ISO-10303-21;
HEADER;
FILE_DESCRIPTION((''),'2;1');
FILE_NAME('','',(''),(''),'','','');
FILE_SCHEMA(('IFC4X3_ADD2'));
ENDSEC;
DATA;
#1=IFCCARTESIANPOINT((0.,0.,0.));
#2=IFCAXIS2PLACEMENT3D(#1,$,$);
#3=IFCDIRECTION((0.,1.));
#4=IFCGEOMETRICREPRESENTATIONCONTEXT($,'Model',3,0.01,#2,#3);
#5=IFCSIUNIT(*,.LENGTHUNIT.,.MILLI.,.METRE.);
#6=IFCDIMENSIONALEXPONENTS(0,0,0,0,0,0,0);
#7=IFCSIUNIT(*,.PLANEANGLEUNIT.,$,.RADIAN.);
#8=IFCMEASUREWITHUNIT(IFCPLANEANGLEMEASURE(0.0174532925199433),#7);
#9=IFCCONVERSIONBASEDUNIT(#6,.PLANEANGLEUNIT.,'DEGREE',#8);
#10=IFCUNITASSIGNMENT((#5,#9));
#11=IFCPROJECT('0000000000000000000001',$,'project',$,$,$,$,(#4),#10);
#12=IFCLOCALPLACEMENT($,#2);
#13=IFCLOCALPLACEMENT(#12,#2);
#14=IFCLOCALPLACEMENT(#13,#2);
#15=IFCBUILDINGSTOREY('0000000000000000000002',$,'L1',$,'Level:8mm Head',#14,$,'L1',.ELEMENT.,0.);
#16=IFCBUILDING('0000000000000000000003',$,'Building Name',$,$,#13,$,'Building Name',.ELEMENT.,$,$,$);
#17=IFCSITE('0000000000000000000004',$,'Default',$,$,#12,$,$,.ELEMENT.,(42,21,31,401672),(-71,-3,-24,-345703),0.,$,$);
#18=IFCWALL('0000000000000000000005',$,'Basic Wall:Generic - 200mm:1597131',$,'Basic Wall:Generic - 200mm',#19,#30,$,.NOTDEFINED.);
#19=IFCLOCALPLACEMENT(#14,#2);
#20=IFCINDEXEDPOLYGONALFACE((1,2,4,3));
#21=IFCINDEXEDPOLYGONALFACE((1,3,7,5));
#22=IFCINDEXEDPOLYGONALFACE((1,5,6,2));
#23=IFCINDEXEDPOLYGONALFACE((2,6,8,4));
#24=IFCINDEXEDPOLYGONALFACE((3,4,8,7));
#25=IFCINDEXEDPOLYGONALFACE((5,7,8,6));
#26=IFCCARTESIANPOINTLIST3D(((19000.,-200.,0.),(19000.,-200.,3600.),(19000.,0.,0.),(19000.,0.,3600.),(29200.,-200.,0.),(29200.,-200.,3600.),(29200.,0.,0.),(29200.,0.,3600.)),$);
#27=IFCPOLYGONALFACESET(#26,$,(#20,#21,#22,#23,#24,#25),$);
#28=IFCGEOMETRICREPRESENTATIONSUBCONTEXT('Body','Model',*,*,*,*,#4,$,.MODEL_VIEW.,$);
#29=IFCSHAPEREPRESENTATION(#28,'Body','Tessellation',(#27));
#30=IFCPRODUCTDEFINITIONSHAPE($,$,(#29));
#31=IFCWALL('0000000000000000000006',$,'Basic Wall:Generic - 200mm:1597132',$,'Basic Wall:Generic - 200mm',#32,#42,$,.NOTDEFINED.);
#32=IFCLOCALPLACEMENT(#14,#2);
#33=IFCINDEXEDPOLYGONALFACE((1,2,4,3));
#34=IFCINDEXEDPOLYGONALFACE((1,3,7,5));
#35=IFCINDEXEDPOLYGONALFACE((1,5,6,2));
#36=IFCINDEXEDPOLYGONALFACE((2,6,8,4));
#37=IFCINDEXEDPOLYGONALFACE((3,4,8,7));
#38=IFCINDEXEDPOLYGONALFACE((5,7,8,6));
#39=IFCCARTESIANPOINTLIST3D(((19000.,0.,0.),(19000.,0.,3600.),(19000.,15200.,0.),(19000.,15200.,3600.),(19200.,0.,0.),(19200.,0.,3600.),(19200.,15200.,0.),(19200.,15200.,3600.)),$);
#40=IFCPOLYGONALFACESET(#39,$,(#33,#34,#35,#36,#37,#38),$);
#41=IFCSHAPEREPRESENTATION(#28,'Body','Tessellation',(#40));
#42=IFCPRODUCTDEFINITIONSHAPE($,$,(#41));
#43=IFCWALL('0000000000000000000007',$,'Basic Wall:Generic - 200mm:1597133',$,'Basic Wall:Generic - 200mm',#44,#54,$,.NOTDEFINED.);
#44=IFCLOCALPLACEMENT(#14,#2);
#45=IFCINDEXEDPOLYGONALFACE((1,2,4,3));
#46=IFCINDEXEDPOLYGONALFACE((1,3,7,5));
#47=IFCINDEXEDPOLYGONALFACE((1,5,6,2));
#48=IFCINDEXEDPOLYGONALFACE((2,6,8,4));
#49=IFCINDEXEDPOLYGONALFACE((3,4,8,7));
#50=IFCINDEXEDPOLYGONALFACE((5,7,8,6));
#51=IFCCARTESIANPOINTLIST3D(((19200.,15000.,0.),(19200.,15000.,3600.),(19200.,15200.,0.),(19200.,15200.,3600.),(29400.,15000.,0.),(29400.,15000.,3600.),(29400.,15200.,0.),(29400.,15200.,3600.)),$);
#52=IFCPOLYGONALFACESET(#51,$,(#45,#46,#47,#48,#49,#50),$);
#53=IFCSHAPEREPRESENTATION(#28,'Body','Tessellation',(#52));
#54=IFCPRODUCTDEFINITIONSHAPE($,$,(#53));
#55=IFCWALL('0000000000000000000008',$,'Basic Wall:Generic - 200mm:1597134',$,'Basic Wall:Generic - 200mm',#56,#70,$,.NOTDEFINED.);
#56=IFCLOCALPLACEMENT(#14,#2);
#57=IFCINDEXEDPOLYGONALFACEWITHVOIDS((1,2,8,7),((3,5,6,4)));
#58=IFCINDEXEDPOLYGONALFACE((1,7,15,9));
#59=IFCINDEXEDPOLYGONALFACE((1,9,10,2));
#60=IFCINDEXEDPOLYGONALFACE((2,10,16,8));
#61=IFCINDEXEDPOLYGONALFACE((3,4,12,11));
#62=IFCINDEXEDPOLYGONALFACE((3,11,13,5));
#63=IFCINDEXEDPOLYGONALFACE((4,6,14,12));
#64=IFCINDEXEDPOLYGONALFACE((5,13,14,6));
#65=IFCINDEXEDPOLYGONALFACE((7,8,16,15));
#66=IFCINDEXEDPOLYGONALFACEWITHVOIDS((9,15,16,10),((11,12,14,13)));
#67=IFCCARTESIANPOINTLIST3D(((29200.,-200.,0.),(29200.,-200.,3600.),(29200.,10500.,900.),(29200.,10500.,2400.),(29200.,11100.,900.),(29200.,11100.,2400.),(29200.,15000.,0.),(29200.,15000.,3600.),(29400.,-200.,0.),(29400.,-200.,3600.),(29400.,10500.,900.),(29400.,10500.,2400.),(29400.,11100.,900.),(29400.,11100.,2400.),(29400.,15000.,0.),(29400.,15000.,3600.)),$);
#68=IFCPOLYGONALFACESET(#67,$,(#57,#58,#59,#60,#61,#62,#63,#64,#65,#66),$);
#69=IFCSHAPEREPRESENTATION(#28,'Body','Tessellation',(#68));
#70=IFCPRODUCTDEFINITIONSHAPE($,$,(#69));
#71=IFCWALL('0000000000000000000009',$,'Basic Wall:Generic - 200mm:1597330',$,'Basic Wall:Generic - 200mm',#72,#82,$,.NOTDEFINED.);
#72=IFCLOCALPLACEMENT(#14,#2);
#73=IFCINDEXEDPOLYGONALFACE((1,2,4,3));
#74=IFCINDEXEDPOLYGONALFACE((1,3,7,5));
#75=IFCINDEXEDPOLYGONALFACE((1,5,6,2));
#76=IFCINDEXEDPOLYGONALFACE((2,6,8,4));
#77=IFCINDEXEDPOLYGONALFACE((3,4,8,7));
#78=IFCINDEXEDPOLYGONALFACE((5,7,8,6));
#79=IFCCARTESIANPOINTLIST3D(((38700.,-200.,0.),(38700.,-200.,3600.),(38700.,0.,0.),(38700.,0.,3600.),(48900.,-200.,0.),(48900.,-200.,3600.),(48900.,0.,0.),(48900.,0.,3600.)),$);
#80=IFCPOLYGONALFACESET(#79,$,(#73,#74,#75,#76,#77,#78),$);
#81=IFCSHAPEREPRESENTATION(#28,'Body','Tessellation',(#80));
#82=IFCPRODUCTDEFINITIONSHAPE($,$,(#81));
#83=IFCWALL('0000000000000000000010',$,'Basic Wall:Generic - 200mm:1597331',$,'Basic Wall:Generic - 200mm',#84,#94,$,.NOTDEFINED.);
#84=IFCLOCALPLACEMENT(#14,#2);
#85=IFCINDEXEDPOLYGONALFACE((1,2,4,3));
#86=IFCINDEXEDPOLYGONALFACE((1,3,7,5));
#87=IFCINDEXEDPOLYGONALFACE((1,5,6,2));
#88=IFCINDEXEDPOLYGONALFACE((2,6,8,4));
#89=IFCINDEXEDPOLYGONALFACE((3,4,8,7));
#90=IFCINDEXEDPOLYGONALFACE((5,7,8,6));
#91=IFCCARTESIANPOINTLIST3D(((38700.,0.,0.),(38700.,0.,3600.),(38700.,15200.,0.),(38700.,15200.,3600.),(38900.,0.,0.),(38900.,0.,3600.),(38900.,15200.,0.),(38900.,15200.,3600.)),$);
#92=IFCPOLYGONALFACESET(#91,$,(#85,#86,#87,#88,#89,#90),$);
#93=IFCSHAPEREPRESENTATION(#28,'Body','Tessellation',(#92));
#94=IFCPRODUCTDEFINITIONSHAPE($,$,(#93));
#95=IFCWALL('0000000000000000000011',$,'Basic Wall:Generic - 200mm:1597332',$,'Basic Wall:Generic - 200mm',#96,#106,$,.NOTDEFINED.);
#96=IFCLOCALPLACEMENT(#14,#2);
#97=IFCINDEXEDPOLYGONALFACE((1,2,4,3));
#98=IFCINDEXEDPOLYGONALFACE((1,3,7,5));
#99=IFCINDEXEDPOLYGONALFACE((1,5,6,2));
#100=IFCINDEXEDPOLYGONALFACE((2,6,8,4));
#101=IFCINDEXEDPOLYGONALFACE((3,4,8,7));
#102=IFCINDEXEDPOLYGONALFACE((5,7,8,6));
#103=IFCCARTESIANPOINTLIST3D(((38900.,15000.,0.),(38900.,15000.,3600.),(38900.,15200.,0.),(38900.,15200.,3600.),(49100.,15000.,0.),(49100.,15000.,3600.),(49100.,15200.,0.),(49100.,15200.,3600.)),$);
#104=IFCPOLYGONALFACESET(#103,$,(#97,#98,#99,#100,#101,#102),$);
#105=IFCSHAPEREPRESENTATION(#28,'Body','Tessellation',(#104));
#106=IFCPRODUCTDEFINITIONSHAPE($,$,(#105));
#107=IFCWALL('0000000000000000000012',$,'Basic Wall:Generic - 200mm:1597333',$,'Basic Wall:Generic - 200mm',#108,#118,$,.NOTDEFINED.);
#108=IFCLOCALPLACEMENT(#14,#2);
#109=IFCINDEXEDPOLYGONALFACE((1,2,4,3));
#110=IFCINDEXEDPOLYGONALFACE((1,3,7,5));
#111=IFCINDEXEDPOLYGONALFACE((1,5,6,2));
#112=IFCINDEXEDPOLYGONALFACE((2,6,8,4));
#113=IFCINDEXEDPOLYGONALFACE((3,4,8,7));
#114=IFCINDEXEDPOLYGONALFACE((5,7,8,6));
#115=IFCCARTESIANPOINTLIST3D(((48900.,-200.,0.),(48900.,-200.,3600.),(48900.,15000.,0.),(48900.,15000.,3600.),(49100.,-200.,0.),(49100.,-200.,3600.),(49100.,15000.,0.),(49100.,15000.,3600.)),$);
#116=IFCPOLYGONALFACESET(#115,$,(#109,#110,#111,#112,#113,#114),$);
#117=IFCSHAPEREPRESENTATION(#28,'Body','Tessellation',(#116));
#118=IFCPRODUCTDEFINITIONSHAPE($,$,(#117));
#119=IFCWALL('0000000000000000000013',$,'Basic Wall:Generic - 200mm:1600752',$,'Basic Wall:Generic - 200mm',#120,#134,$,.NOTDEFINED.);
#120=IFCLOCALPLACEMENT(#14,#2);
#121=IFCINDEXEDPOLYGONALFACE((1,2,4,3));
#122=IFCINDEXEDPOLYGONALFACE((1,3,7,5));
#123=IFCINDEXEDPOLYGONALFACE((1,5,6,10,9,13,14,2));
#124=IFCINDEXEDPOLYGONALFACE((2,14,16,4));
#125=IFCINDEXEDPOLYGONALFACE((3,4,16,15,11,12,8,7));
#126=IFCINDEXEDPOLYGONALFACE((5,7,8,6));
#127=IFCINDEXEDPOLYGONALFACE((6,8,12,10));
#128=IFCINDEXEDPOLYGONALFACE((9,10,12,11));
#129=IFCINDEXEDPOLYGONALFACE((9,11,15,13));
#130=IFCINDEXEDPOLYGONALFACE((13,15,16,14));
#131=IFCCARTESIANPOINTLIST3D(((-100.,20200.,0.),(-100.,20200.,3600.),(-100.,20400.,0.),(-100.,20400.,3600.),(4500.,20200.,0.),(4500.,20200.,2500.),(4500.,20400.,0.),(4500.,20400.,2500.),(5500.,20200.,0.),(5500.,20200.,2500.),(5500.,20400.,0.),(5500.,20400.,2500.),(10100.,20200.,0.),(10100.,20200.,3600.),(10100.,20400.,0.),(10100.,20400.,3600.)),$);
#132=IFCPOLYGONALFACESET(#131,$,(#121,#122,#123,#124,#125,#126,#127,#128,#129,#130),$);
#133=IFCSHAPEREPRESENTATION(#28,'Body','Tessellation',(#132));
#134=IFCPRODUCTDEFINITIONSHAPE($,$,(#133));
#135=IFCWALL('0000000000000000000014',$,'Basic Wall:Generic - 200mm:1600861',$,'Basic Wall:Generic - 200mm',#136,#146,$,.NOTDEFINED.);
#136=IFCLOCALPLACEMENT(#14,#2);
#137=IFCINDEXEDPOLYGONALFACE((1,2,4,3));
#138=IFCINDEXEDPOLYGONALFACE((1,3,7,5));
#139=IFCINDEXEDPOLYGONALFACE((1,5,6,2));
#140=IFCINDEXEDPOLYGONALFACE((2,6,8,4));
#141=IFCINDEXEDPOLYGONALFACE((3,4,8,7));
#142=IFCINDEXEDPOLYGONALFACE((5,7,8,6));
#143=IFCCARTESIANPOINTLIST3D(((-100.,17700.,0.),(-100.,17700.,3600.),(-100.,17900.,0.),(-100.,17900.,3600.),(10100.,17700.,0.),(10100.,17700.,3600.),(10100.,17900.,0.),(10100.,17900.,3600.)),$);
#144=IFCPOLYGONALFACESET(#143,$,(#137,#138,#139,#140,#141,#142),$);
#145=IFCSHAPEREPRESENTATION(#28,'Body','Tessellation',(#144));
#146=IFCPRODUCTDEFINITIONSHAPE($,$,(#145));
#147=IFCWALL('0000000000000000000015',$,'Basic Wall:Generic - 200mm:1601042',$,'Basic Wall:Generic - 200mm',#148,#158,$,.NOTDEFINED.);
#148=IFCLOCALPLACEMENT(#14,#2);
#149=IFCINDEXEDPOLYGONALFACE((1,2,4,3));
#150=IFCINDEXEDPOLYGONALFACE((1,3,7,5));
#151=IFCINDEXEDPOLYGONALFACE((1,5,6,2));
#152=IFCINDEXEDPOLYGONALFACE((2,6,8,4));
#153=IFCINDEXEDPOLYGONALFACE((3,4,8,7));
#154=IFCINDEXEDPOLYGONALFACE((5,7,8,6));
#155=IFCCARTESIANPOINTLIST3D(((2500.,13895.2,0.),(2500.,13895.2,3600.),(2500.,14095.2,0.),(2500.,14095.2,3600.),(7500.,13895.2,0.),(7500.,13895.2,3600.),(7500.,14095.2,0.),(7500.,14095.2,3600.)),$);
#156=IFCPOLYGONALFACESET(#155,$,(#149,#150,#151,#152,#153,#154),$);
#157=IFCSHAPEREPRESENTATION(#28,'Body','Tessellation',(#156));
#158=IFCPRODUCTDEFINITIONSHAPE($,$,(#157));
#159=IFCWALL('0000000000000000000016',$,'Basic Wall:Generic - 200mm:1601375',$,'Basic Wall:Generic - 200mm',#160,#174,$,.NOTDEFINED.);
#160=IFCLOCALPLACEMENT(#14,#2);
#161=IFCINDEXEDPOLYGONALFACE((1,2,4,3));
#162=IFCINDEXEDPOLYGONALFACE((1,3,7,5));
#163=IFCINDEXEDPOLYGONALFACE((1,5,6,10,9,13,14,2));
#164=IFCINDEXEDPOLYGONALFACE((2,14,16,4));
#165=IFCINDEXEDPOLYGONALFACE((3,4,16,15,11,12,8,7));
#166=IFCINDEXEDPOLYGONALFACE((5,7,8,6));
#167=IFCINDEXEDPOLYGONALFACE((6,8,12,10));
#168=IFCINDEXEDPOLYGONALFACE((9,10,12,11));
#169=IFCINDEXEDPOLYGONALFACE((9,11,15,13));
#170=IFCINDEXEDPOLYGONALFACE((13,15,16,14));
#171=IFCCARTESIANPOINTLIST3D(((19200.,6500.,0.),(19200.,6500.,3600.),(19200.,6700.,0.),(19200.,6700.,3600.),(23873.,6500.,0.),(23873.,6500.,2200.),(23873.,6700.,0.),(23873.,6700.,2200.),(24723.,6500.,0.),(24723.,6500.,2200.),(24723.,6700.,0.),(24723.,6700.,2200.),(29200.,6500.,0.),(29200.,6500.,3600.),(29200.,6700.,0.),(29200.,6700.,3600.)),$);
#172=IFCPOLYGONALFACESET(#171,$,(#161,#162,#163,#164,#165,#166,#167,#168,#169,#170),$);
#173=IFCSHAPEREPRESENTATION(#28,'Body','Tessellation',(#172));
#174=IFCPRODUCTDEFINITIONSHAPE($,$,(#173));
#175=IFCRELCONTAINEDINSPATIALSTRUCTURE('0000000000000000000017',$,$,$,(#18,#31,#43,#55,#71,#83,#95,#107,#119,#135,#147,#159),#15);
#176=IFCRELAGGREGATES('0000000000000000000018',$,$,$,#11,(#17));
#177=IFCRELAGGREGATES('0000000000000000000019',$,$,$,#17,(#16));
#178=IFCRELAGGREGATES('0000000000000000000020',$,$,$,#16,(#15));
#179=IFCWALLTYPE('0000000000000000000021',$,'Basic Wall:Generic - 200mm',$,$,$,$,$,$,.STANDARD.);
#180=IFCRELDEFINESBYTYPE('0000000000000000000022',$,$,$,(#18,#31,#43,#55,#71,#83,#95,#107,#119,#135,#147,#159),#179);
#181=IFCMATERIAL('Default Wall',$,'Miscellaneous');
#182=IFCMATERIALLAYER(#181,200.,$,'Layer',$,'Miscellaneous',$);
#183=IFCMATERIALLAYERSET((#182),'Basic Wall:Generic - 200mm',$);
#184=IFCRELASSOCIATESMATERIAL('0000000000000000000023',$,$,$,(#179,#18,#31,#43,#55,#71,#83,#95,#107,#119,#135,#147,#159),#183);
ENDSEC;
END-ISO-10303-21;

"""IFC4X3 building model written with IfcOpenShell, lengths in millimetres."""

from ifc_helpers import new_model, entity, si_unit, converted_unit, direction, frame, frame_2d, origin, origin_2d_with_axis, place, context, subcontext, project, spatial, rectangle, extrude, material, layer, layer_set, type_object, element, save


model = new_model("IFC4X3")

# Units and contexts
model_context = context("Model", 3, precision=0.01, world=origin(), true_north=direction((0.0, 1.0)))
body_context = subcontext(model_context, "Body", "Model", "MODEL_VIEW")
ifc_project = project(units=[si_unit("LENGTHUNIT", "METRE", prefix="MILLI"), converted_unit("PLANEANGLEUNIT", "DEGREE", entity("IfcPlaneAngleMeasure", 0.0174532925199433), si_unit("PLANEANGLEUNIT", "RADIAN"), dimensions=[0, 0, 0, 0, 0, 0, 0])], contexts=[model_context])

# Site, building, storey
site_placement = place(None, origin())
site = spatial("IfcSite", under=ifc_project, at=site_placement, Name="Default", CompositionType="ELEMENT", RefLatitude=(42, 21, 31, 401672), RefLongitude=(-71, -3, -24, -345703), RefElevation=0.0)
building_placement = place(site_placement, origin())
building = spatial("IfcBuilding", under=site, at=building_placement, Name="Building Name", LongName="Building Name", CompositionType="ELEMENT")
storey_placement = place(building_placement, origin())
storey = spatial("IfcBuildingStorey", under=building, at=storey_placement, Name="L1", ObjectType="Level:8mm Head", LongName="L1", CompositionType="ELEMENT", Elevation=0.0)

# Walls
ifc_material_1 = material(Name="Default Wall", Category="Miscellaneous")
ifc_layer_1 = layer(ifc_material_1, 200.0, Name="Layer", Category="Miscellaneous")
ifc_layer_set_1 = layer_set([ifc_layer_1], Name="Basic Wall:Generic - 200mm")
wall_type_1 = type_object("IfcWallType", Name="Basic Wall:Generic - 200mm", PredefinedType="STANDARD", material=ifc_layer_set_1)
wall_1_placement = place(storey_placement, frame((19000.0, -100.0, 0.0)))
element("IfcWall", 1, at=wall_1_placement, inside=storey, type_object=wall_type_1, material=ifc_layer_set_1, Name="Basic Wall:Generic - 200mm:1597131", ObjectType="Basic Wall:Generic - 200mm", PredefinedType="NOTDEFINED", context=body_context, shape_type="SweptSolid", body=[
    extrude(rectangle(XDim=10200.0, YDim=200.0, at=frame_2d((5100.0, 0.0), x_axis=(-1.0, 0.0))), origin(), (0.0, 0.0, 1.0), 3600.0),
])
wall_2_placement = place(storey_placement, frame((19100.0, 15200.0, 0.0), z_axis=(0.0, 0.0, 1.0), x_axis=(0.0, -1.0, 0.0)))
element("IfcWall", 2, at=wall_2_placement, inside=storey, type_object=wall_type_1, material=ifc_layer_set_1, Name="Basic Wall:Generic - 200mm:1597132", ObjectType="Basic Wall:Generic - 200mm", PredefinedType="NOTDEFINED", context=body_context, shape_type="SweptSolid", body=[
    extrude(rectangle(XDim=15200.0, YDim=200.0, at=frame_2d((7600.0, 0.0), x_axis=(-1.0, 0.0))), origin(), (0.0, 0.0, 1.0), 3600.0),
])
wall_3_placement = place(storey_placement, frame((29400.0, 15100.0, 0.0), z_axis=(0.0, 0.0, 1.0), x_axis=(-1.0, 0.0, 0.0)))
element("IfcWall", 3, at=wall_3_placement, inside=storey, type_object=wall_type_1, material=ifc_layer_set_1, Name="Basic Wall:Generic - 200mm:1597133", ObjectType="Basic Wall:Generic - 200mm", PredefinedType="NOTDEFINED", context=body_context, shape_type="SweptSolid", body=[
    extrude(rectangle(XDim=10200.0, YDim=200.0, at=frame_2d((5100.0, 0.0), x_axis=(-1.0, 0.0))), origin(), (0.0, 0.0, 1.0), 3600.0),
])

# Wall, opening
wall_4_placement = place(storey_placement, frame((29300.0, -200.0, 0.0), z_axis=(0.0, 0.0, 1.0), x_axis=(0.0, 1.0, 0.0)))
wall_4 = element("IfcWall", 4, at=wall_4_placement, inside=storey, type_object=wall_type_1, material=ifc_layer_set_1, Name="Basic Wall:Generic - 200mm:1597134", ObjectType="Basic Wall:Generic - 200mm", PredefinedType="NOTDEFINED", context=body_context, shape_type="SweptSolid", body=[
    extrude(rectangle(XDim=15200.0, YDim=200.0, at=frame_2d((7600.0, 0.0), x_axis=(-1.0, 0.0))), origin(), (0.0, 0.0, 1.0), 3600.0),
])
opening_1_placement = place(wall_4_placement, frame((11300.0, 100.0, 900.0)))
element("IfcOpeningElement", 5, at=opening_1_placement, cuts=wall_4, PredefinedType="OPENING", context=body_context, shape_type="SweptSolid", body=[
    extrude(rectangle(XDim=1500.0, YDim=600.0, at=frame_2d((750.0, 300.0), x_axis=(-1.0, 0.0))), frame((0.0, 0.0, 0.0), z_axis=(0.0, -1.0, 0.0), x_axis=(0.0, 0.0, 1.0)), (0.0, 0.0, 1.0), 200.0),
])

# Walls
wall_5_placement = place(storey_placement, frame((38700.0, -100.0, 0.0)))
element("IfcWall", 6, at=wall_5_placement, inside=storey, type_object=wall_type_1, material=ifc_layer_set_1, Name="Basic Wall:Generic - 200mm:1597330", ObjectType="Basic Wall:Generic - 200mm", PredefinedType="NOTDEFINED", context=body_context, shape_type="SweptSolid", body=[
    extrude(rectangle(XDim=10200.0, YDim=200.0, at=frame_2d((5100.0, 0.0), x_axis=(-1.0, 0.0))), origin(), (0.0, 0.0, 1.0), 3600.0),
])
wall_6_placement = place(storey_placement, frame((38800.0, 15200.0, 0.0), z_axis=(0.0, 0.0, 1.0), x_axis=(0.0, -1.0, 0.0)))
element("IfcWall", 7, at=wall_6_placement, inside=storey, type_object=wall_type_1, material=ifc_layer_set_1, Name="Basic Wall:Generic - 200mm:1597331", ObjectType="Basic Wall:Generic - 200mm", PredefinedType="NOTDEFINED", context=body_context, shape_type="SweptSolid", body=[
    extrude(rectangle(XDim=15200.0, YDim=200.0, at=frame_2d((7600.0, 0.0), x_axis=(-1.0, 0.0))), origin(), (0.0, 0.0, 1.0), 3600.0),
])
wall_7_placement = place(storey_placement, frame((49100.0, 15100.0, 0.0), z_axis=(0.0, 0.0, 1.0), x_axis=(-1.0, 0.0, 0.0)))
element("IfcWall", 8, at=wall_7_placement, inside=storey, type_object=wall_type_1, material=ifc_layer_set_1, Name="Basic Wall:Generic - 200mm:1597332", ObjectType="Basic Wall:Generic - 200mm", PredefinedType="NOTDEFINED", context=body_context, shape_type="SweptSolid", body=[
    extrude(rectangle(XDim=10200.0, YDim=200.0, at=frame_2d((5100.0, 0.0), x_axis=(-1.0, 0.0))), origin(), (0.0, 0.0, 1.0), 3600.0),
])
wall_8_placement = place(storey_placement, frame((49000.0, -200.0, 0.0), z_axis=(0.0, 0.0, 1.0), x_axis=(0.0, 1.0, 0.0)))
element("IfcWall", 9, at=wall_8_placement, inside=storey, type_object=wall_type_1, material=ifc_layer_set_1, Name="Basic Wall:Generic - 200mm:1597333", ObjectType="Basic Wall:Generic - 200mm", PredefinedType="NOTDEFINED", context=body_context, shape_type="SweptSolid", body=[
    extrude(rectangle(XDim=15200.0, YDim=200.0, at=frame_2d((7600.0, 0.0), x_axis=(-1.0, 0.0))), origin(), (0.0, 0.0, 1.0), 3600.0),
])

# Wall, opening
wall_9_placement = place(storey_placement, frame((10100.0, 20300.0, 0.0), z_axis=(0.0, 0.0, 1.0), x_axis=(-1.0, 0.0, 0.0)))
wall_9 = element("IfcWall", 10, at=wall_9_placement, inside=storey, type_object=wall_type_1, material=ifc_layer_set_1, Name="Basic Wall:Generic - 200mm:1600752", ObjectType="Basic Wall:Generic - 200mm", PredefinedType="NOTDEFINED", context=body_context, shape_type="SweptSolid", body=[
    extrude(rectangle(XDim=10200.0, YDim=200.0, at=frame_2d((5100.0, 0.0), x_axis=(1.0, 0.0))), origin(), (0.0, 0.0, 1.0), 3600.0),
])
opening_2_placement = place(wall_9_placement, frame((5600.0, 100.0, 0.0)))
element("IfcOpeningElement", 11, at=opening_2_placement, cuts=wall_9, PredefinedType="OPENING", context=body_context, shape_type="SweptSolid", body=[
    extrude(rectangle(XDim=2500.0, YDim=1000.0, at=origin_2d_with_axis()), frame((-500.0, -200.0, 1250.0), z_axis=(0.0, 1.0, 0.0), x_axis=(0.0, 0.0, -1.0)), (0.0, 0.0, 1.0), 200.0),
])

# Walls
wall_10_placement = place(storey_placement, frame((10100.0, 17800.0, 0.0), z_axis=(0.0, 0.0, 1.0), x_axis=(-1.0, 0.0, 0.0)))
element("IfcWall", 12, at=wall_10_placement, inside=storey, type_object=wall_type_1, material=ifc_layer_set_1, Name="Basic Wall:Generic - 200mm:1600861", ObjectType="Basic Wall:Generic - 200mm", PredefinedType="NOTDEFINED", context=body_context, shape_type="SweptSolid", body=[
    extrude(rectangle(XDim=10200.0, YDim=200.0, at=frame_2d((5100.0, 0.0), x_axis=(-1.0, 0.0))), origin(), (0.0, 0.0, 1.0), 3600.0),
])
wall_11_placement = place(storey_placement, frame((7500.0, 13995.2, 0.0), z_axis=(0.0, 0.0, 1.0), x_axis=(-1.0, 0.0, 0.0)))
element("IfcWall", 13, at=wall_11_placement, inside=storey, type_object=wall_type_1, material=ifc_layer_set_1, Name="Basic Wall:Generic - 200mm:1601042", ObjectType="Basic Wall:Generic - 200mm", PredefinedType="NOTDEFINED", context=body_context, shape_type="SweptSolid", body=[
    extrude(rectangle(XDim=5000.0, YDim=200.0, at=frame_2d((2500.0, 0.0), x_axis=(-1.0, 0.0))), origin(), (0.0, 0.0, 1.0), 3600.0),
])

# Wall, opening
wall_12_placement = place(storey_placement, frame((29200.0, 6600.0, 0.0), z_axis=(0.0, 0.0, 1.0), x_axis=(-1.0, 0.0, 0.0)))
wall_12 = element("IfcWall", 14, at=wall_12_placement, inside=storey, type_object=wall_type_1, material=ifc_layer_set_1, Name="Basic Wall:Generic - 200mm:1601375", ObjectType="Basic Wall:Generic - 200mm", PredefinedType="NOTDEFINED", context=body_context, shape_type="SweptSolid", body=[
    extrude(rectangle(XDim=10000.0, YDim=200.0, at=frame_2d((5000.0, 0.0), x_axis=(1.0, 0.0))), origin(), (0.0, 0.0, 1.0), 3600.0),
])
opening_3_placement = place(wall_12_placement, frame((5327.0, 100.0, 0.0)))
element("IfcOpeningElement", 15, at=opening_3_placement, cuts=wall_12, PredefinedType="OPENING", context=body_context, shape_type="SweptSolid", body=[
    extrude(rectangle(XDim=2200.0, YDim=850.0, at=frame_2d((1100.0, 425.0), x_axis=(1.0, 0.0))), frame((0.0, 0.0, 0.0), z_axis=(0.0, -1.0, 0.0), x_axis=(0.0, 0.0, 1.0)), (0.0, 0.0, 1.0), 200.0),
])

save(model, "model.ifc")
